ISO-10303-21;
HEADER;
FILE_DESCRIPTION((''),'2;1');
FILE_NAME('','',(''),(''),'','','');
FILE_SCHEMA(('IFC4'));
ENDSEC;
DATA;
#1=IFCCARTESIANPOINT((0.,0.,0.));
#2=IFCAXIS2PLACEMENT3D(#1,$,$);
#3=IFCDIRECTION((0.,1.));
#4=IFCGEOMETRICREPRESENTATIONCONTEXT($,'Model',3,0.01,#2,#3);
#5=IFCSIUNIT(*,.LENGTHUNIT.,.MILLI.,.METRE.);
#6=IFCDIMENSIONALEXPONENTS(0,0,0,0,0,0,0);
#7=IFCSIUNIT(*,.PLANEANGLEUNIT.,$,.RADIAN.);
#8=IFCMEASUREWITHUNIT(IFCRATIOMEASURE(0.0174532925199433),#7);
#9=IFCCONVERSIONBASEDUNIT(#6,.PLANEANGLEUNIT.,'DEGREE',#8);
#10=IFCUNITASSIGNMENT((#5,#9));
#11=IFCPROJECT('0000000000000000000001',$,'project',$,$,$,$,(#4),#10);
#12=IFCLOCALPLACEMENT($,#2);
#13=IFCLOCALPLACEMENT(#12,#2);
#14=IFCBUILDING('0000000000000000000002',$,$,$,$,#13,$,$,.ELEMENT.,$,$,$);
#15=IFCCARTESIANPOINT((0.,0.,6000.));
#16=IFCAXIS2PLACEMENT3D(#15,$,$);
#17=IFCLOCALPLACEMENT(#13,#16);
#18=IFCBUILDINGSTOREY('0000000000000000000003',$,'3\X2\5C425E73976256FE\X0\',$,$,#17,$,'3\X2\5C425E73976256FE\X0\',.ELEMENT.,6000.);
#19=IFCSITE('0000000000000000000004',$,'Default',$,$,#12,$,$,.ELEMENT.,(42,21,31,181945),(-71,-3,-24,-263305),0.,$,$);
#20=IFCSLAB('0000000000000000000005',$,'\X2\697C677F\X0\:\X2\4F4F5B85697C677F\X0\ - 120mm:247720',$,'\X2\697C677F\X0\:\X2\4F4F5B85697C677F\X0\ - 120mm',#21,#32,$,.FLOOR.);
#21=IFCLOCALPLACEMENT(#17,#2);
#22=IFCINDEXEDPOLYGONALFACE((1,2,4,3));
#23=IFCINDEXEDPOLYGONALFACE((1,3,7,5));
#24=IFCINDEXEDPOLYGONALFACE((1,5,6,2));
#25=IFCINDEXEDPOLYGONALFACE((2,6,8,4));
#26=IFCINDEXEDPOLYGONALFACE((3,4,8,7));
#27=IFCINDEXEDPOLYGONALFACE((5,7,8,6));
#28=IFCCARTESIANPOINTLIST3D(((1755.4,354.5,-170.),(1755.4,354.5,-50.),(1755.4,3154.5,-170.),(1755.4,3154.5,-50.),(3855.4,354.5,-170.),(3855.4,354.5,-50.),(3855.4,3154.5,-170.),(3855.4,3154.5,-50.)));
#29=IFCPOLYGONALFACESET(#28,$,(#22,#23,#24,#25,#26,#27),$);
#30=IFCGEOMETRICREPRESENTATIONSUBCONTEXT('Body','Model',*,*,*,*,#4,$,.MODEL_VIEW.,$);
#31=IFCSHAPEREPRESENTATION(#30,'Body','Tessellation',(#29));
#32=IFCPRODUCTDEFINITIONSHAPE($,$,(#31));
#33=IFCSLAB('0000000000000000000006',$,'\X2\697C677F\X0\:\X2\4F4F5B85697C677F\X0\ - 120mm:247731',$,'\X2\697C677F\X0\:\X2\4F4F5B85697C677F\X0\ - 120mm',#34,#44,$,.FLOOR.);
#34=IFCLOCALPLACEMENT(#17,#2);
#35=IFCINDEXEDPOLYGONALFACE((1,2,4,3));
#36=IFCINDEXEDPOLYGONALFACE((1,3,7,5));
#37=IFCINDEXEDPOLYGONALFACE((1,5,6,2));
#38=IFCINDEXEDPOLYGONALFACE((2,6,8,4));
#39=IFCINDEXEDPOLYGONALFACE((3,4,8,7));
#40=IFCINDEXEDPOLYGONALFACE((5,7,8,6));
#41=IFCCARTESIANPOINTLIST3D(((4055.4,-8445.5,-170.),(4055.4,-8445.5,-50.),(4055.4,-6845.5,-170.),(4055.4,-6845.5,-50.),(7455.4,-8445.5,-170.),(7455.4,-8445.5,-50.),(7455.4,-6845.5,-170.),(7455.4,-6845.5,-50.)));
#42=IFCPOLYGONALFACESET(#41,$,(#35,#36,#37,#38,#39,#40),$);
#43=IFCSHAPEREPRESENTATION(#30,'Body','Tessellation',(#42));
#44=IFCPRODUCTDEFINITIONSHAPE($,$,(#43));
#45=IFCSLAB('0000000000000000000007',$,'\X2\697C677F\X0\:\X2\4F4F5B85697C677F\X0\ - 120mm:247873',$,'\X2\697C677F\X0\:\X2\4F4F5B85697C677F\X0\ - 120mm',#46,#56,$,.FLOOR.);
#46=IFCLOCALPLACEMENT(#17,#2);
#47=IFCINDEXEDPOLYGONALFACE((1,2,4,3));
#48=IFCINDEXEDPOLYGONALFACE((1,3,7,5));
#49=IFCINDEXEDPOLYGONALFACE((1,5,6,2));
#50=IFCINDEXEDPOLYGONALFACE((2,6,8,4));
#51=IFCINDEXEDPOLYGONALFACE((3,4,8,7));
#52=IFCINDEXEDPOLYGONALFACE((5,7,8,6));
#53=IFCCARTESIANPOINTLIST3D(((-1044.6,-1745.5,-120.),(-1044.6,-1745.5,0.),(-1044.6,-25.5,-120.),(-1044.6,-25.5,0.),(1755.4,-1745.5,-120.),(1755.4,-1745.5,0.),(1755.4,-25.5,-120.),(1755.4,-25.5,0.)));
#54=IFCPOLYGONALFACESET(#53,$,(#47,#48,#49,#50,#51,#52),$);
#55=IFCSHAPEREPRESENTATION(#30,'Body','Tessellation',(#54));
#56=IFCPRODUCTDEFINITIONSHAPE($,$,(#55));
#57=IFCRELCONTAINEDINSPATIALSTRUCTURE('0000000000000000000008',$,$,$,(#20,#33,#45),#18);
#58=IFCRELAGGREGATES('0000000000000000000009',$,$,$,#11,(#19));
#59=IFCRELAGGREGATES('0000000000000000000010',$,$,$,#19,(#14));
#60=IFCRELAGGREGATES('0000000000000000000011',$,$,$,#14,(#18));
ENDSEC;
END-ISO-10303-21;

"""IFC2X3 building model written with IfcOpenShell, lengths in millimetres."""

from ifc_helpers import new_model, entity, si_unit, converted_unit, direction, frame, frame_2d, origin, origin_2d_with_axis, place, context, subcontext, project, spatial, rectangle, extrude, element, save


model = new_model("IFC2X3")

# Units and contexts
model_context = context("Model", 3, precision=0.01, world=origin(), true_north=direction((0.0, 1.0)))
body_context = subcontext(model_context, "Body", "Model", "MODEL_VIEW")
ifc_project = project(units=[si_unit("LENGTHUNIT", "METRE", prefix="MILLI"), converted_unit("PLANEANGLEUNIT", "DEGREE", entity("IfcRatioMeasure", 0.0174532925199433), si_unit("PLANEANGLEUNIT", "RADIAN"), dimensions=[0, 0, 0, 0, 0, 0, 0])], contexts=[model_context])

# Site, building, storey
site_placement = place(None, origin())
site = spatial("IfcSite", under=ifc_project, at=site_placement, Name="Default", CompositionType="ELEMENT", RefLatitude=(42, 21, 31, 181945), RefLongitude=(-71, -3, -24, -263305), RefElevation=0.0)
building_placement = place(site_placement, origin())
building = spatial("IfcBuilding", under=site, at=building_placement, CompositionType="ELEMENT")
storey_placement = place(building_placement, frame((0.0, 0.0, 6000.0)))
storey = spatial("IfcBuildingStorey", under=building, at=storey_placement, Name="3层平面图", LongName="3层平面图", CompositionType="ELEMENT", Elevation=6000.0)

# Slabs
slab_1_placement = place(storey_placement, origin())
element("IfcSlab", 1, at=slab_1_placement, inside=storey, Name="楼板:住宅楼板 - 120mm:247720", ObjectType="楼板:住宅楼板 - 120mm", PredefinedType="FLOOR", context=body_context, shape_type="SweptSolid", body=[
    extrude(rectangle(XDim=2800.0, YDim=2100.0, at=origin_2d_with_axis()), frame((2805.4, 1754.5, -50.0), z_axis=(0.0, 0.0, -1.0), x_axis=(0.0, 1.0, 0.0)), (0.0, 0.0, 1.0), 120.0),
])
slab_2_placement = place(storey_placement, origin())
element("IfcSlab", 2, at=slab_2_placement, inside=storey, Name="楼板:住宅楼板 - 120mm:247731", ObjectType="楼板:住宅楼板 - 120mm", PredefinedType="FLOOR", context=body_context, shape_type="SweptSolid", body=[
    extrude(rectangle(XDim=1600.0, YDim=3400.0, at=frame_2d((0.0, 0.0), x_axis=(1.0, 0.0))), frame((5755.4, -7645.5, -50.0), z_axis=(0.0, 0.0, -1.0), x_axis=(0.0, 1.0, 0.0)), (0.0, 0.0, 1.0), 120.0),
])
slab_3_placement = place(storey_placement, origin())
element("IfcSlab", 3, at=slab_3_placement, inside=storey, Name="楼板:住宅楼板 - 120mm:247873", ObjectType="楼板:住宅楼板 - 120mm", PredefinedType="FLOOR", context=body_context, shape_type="SweptSolid", body=[
    extrude(rectangle(XDim=1720.0, YDim=2800.0, at=origin_2d_with_axis()), frame((355.4, -885.5, 0.0), z_axis=(0.0, 0.0, -1.0), x_axis=(0.0, 1.0, 0.0)), (0.0, 0.0, 1.0), 120.0),
])

save(model, "model.ifc")
